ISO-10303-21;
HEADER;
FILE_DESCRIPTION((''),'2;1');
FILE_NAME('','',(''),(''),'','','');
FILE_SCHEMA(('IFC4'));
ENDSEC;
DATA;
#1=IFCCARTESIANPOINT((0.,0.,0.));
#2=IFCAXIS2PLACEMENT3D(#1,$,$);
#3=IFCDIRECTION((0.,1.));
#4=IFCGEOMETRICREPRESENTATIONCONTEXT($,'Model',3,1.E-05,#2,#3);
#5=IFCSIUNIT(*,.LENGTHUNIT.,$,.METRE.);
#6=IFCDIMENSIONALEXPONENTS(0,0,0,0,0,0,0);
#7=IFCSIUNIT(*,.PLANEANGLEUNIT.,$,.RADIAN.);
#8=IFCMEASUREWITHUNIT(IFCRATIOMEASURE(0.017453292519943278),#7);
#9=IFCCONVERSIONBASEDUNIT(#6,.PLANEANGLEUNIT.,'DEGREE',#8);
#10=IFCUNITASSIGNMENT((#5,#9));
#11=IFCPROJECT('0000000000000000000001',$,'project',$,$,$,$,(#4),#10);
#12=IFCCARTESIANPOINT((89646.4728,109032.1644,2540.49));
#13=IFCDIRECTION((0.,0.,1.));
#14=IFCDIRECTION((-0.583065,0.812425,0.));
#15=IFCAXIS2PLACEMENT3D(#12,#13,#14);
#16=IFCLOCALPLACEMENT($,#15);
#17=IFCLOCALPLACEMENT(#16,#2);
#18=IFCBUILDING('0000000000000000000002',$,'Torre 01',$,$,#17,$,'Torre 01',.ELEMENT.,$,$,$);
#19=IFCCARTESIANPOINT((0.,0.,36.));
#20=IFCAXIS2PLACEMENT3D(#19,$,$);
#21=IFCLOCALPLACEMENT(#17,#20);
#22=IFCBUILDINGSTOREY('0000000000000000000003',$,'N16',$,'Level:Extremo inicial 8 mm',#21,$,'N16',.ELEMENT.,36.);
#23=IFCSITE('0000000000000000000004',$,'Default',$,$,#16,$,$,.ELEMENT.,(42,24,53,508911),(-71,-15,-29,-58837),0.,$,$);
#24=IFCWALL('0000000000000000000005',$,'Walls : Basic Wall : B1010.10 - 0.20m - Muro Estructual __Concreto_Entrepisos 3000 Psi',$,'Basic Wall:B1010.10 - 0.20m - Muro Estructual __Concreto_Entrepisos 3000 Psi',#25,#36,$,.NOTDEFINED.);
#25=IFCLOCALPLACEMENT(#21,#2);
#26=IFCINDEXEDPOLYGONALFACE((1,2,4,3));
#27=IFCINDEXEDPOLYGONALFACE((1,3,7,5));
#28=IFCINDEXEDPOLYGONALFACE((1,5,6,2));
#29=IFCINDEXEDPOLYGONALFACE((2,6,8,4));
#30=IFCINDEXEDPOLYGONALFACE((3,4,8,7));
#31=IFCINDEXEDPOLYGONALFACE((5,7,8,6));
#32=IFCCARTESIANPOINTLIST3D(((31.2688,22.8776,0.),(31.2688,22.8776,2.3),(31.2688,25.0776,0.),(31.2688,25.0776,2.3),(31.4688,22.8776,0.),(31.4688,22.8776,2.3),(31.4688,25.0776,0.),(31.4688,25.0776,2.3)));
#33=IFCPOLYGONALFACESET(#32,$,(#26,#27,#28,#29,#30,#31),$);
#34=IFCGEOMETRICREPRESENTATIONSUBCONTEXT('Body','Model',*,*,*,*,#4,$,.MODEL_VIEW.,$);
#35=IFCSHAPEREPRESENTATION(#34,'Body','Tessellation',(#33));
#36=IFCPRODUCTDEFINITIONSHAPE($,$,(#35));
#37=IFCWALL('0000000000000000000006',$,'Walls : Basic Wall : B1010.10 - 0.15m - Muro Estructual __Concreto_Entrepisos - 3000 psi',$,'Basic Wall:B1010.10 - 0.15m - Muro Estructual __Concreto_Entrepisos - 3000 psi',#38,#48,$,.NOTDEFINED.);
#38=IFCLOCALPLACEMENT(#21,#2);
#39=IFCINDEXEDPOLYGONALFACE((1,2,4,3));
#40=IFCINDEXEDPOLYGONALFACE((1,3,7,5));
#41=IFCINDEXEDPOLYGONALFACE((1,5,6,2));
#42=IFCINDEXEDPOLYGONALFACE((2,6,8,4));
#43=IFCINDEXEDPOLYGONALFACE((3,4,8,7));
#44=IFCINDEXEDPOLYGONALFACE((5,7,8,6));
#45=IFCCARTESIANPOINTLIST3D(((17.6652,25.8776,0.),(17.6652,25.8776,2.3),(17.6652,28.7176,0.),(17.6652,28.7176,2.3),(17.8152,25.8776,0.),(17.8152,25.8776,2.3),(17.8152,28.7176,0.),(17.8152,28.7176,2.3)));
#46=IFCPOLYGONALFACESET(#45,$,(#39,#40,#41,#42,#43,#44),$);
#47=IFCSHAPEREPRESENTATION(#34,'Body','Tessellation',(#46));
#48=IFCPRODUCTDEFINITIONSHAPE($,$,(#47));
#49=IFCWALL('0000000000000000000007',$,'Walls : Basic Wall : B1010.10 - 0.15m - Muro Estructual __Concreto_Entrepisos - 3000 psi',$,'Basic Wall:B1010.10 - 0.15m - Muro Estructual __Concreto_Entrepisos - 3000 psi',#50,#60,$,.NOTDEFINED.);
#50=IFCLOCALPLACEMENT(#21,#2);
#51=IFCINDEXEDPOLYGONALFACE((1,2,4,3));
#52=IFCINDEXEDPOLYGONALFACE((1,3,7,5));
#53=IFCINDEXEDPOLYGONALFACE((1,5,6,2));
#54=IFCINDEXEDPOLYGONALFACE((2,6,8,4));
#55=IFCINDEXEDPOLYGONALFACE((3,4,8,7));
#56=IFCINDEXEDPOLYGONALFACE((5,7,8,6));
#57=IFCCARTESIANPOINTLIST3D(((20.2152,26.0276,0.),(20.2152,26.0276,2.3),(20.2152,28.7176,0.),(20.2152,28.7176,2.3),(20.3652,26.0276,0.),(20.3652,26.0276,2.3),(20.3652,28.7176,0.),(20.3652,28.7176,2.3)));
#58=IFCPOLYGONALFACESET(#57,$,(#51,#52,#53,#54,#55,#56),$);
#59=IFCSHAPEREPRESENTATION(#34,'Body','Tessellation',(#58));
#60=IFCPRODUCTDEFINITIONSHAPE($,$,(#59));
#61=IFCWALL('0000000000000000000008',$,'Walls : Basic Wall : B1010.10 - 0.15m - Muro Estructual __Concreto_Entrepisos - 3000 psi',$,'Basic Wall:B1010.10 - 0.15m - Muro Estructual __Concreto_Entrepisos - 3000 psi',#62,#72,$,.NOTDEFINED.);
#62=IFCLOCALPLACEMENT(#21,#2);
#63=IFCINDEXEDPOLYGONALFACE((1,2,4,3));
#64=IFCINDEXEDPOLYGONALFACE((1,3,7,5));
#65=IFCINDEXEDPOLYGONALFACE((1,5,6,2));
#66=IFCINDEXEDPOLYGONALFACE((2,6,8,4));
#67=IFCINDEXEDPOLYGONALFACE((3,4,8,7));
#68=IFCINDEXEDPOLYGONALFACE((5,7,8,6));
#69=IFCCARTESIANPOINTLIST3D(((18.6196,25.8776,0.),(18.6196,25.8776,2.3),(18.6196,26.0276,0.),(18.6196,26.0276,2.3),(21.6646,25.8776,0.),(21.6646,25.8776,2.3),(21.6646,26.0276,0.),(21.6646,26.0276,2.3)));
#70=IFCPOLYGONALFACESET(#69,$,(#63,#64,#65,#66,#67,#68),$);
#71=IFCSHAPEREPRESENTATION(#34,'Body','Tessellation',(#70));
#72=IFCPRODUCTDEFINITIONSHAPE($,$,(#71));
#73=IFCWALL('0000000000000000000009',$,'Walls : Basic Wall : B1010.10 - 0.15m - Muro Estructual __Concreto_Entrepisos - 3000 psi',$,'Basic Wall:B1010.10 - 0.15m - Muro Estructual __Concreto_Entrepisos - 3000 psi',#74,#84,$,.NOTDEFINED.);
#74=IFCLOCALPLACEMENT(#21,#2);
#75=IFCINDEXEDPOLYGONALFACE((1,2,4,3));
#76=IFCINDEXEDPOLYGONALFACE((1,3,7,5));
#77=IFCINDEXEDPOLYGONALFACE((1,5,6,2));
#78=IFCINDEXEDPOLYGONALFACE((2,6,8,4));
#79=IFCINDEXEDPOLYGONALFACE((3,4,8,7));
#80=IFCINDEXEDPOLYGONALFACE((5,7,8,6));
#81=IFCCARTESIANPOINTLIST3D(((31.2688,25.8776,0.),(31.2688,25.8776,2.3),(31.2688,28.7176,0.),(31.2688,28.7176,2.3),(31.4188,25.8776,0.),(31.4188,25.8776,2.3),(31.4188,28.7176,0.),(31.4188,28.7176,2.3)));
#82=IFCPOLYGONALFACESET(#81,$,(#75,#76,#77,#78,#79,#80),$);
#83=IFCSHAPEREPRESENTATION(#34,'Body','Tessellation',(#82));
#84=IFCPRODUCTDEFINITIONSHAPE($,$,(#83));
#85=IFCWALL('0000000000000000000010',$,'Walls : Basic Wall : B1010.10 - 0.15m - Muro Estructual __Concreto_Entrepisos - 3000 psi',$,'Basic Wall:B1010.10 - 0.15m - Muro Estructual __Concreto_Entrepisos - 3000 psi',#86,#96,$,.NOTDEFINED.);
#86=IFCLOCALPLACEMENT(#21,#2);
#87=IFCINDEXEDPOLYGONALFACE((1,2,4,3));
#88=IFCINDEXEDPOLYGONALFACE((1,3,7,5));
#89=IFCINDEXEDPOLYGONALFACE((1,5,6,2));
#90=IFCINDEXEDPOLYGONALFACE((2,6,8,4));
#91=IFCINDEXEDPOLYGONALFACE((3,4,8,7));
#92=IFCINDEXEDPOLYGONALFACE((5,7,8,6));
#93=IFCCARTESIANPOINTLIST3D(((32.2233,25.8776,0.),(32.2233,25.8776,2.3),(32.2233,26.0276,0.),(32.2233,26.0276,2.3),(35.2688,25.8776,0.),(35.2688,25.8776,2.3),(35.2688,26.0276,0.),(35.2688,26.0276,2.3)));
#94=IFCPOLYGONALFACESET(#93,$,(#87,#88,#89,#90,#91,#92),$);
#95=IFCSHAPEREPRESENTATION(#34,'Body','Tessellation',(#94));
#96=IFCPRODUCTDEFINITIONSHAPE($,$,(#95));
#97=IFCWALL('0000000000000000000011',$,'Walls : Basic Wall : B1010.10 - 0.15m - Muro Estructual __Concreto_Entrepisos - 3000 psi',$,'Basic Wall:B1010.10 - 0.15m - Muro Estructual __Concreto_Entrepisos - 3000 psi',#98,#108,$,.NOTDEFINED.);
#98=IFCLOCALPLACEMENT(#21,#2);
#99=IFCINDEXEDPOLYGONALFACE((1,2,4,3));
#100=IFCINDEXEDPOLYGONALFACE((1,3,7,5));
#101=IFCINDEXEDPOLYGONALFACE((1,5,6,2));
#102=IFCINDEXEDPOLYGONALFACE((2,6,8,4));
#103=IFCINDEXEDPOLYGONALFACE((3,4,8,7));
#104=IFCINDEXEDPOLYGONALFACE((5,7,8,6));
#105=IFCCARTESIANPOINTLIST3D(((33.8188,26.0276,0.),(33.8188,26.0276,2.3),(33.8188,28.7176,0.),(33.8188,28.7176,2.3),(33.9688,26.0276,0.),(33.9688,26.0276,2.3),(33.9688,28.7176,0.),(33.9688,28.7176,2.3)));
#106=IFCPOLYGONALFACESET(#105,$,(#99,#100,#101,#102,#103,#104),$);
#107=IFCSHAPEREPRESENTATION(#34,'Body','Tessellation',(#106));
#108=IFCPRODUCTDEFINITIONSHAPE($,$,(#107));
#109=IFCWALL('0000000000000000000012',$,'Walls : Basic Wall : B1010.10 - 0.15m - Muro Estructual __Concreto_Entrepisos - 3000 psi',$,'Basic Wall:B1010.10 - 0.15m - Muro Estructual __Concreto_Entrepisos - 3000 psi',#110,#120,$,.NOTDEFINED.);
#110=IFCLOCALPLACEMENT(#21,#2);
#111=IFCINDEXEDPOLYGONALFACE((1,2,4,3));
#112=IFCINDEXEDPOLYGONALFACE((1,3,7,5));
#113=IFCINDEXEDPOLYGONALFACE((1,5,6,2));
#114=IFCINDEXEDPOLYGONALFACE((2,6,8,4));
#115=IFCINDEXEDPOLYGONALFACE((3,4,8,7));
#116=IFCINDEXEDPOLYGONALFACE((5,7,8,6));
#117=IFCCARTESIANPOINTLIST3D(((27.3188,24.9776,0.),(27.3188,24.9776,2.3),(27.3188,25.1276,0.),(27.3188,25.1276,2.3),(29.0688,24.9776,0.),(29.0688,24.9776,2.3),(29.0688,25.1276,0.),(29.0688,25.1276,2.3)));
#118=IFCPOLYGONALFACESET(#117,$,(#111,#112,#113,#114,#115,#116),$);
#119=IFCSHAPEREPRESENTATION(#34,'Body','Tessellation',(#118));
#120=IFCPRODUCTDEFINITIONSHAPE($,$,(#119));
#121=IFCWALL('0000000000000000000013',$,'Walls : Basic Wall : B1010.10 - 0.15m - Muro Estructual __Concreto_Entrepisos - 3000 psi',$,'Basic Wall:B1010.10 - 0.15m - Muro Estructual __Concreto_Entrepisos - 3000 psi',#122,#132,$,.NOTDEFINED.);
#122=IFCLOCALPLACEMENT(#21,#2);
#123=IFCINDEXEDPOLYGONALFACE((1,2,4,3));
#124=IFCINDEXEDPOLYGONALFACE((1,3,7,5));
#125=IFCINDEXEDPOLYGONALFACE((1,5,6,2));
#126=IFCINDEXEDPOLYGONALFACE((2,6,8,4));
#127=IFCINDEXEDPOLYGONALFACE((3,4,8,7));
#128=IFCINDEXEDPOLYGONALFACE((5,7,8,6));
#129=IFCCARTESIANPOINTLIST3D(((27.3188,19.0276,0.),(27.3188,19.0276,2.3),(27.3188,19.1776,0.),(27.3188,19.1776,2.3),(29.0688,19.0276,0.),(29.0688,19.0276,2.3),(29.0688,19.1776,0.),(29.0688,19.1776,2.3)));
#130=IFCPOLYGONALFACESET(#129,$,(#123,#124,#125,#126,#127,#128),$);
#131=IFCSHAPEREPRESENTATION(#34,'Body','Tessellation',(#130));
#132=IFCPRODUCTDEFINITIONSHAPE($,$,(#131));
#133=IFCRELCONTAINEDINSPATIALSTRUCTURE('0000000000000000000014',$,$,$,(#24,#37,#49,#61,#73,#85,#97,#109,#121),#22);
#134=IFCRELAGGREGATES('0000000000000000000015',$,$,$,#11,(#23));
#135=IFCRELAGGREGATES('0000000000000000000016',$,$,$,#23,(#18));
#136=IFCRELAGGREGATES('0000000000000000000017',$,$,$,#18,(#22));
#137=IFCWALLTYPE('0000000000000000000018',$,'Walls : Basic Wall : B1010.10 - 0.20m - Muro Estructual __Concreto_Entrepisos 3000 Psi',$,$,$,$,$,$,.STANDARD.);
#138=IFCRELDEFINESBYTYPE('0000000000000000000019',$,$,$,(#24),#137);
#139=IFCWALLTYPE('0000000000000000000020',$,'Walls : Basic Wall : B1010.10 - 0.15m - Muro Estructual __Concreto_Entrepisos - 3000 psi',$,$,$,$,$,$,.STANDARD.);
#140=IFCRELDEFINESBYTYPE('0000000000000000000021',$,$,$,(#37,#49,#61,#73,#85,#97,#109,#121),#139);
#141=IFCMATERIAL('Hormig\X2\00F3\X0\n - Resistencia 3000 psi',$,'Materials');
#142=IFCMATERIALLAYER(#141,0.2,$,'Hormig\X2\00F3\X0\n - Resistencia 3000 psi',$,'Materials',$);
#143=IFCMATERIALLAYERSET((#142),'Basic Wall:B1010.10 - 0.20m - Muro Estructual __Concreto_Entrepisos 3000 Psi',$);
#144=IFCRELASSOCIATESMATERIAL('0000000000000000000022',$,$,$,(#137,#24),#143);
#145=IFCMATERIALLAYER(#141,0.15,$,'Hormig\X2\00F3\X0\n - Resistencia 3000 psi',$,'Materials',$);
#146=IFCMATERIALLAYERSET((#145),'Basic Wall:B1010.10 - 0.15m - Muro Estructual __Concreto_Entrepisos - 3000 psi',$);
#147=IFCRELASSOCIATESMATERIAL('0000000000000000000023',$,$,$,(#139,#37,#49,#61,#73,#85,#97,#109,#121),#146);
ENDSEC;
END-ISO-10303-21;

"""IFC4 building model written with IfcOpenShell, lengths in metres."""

from ifc_helpers import new_model, entity, si_unit, converted_unit, direction, frame, frame_2d, origin, place, context, subcontext, project, spatial, rectangle, extrude, material, layer, layer_set, layer_usage, type_object, element, save


model = new_model("IFC4")

# Units and contexts
model_context = context("Model", 3, precision=1e-05, world=origin(), true_north=direction((0.0, 1.0)))
body_context = subcontext(model_context, "Body", "Model", "MODEL_VIEW")
ifc_project = project(units=[si_unit("LENGTHUNIT", "METRE"), converted_unit("PLANEANGLEUNIT", "DEGREE", entity("IfcRatioMeasure", 0.017453292519943278), si_unit("PLANEANGLEUNIT", "RADIAN"), dimensions=[0, 0, 0, 0, 0, 0, 0])], contexts=[model_context])

# Site, building, storey
site_placement = place(None, frame((89646.4728, 109032.1644, 2540.49), z_axis=(0.0, 0.0, 1.0), x_axis=(-0.583065, 0.812425, 0.0)))
site = spatial("IfcSite", under=ifc_project, at=site_placement, Name="Default", CompositionType="ELEMENT", RefLatitude=(42, 24, 53, 508911), RefLongitude=(-71, -15, -29, -58837), RefElevation=0.0)
building_placement = place(site_placement, origin())
building = spatial("IfcBuilding", under=site, at=building_placement, Name="Torre 01", LongName="Torre 01", CompositionType="ELEMENT")
storey_placement = place(building_placement, frame((0.0, 0.0, 36.0)))
storey = spatial("IfcBuildingStorey", under=building, at=storey_placement, Name="N16", ObjectType="Level:Extremo inicial 8 mm", LongName="N16", CompositionType="ELEMENT", Elevation=36.0)

# Walls
ifc_material = material(Name="Hormigón - Resistencia 3000 psi", Category="Materials")
ifc_layer_1 = layer(ifc_material, 0.2, Name="Hormigón - Resistencia 3000 psi", Category="Materials")
ifc_layer_set_1 = layer_set([ifc_layer_1], Name="Basic Wall:B1010.10 - 0.20m - Muro Estructual __Concreto_Entrepisos 3000 Psi")
wall_type_1 = type_object("IfcWallType", Name="Walls : Basic Wall : B1010.10 - 0.20m - Muro Estructual __Concreto_Entrepisos 3000 Psi", PredefinedType="STANDARD", material=ifc_layer_set_1)
ifc_layer_usage_1 = layer_usage(ifc_layer_set_1, "AXIS2", "POSITIVE", -0.1)
wall_1_placement = place(storey_placement, frame((31.3688, 22.8776, 0.0), z_axis=(0.0, 0.0, 1.0), x_axis=(0.0, 1.0, 0.0)))
element("IfcWall", 1, at=wall_1_placement, inside=storey, type_object=wall_type_1, material=ifc_layer_usage_1, Name="Walls : Basic Wall : B1010.10 - 0.20m - Muro Estructual __Concreto_Entrepisos 3000 Psi", ObjectType="Basic Wall:B1010.10 - 0.20m - Muro Estructual __Concreto_Entrepisos 3000 Psi", PredefinedType="NOTDEFINED", context=body_context, shape_type="SweptSolid", body=[
    extrude(rectangle(XDim=2.2, YDim=0.2, at=frame_2d((1.1, 0.0), x_axis=(-1.0, 0.0))), origin(), (0.0, 0.0, 1.0), 2.3),
])
ifc_layer_2 = layer(ifc_material, 0.15, Name="Hormigón - Resistencia 3000 psi", Category="Materials")
ifc_layer_set_2 = layer_set([ifc_layer_2], Name="Basic Wall:B1010.10 - 0.15m - Muro Estructual __Concreto_Entrepisos - 3000 psi")
ifc_layer_usage_2 = layer_usage(ifc_layer_set_2, "AXIS2", "POSITIVE", -0.075)
wall_type_2 = type_object("IfcWallType", Name="Walls : Basic Wall : B1010.10 - 0.15m - Muro Estructual __Concreto_Entrepisos - 3000 psi", PredefinedType="STANDARD", material=ifc_layer_set_2)
wall_2_placement = place(storey_placement, frame((17.7402, 25.8776, 0.0), z_axis=(0.0, 0.0, 1.0), x_axis=(0.0, 1.0, 0.0)))
element("IfcWall", 2, at=wall_2_placement, inside=storey, type_object=wall_type_2, material=ifc_layer_usage_2, Name="Walls : Basic Wall : B1010.10 - 0.15m - Muro Estructual __Concreto_Entrepisos - 3000 psi", ObjectType="Basic Wall:B1010.10 - 0.15m - Muro Estructual __Concreto_Entrepisos - 3000 psi", PredefinedType="NOTDEFINED", context=body_context, shape_type="SweptSolid", body=[
    extrude(rectangle(XDim=2.84, YDim=0.15, at=frame_2d((1.42, 0.0), x_axis=(-1.0, 0.0))), origin(), (0.0, 0.0, 1.0), 2.3),
])
ifc_layer_usage_3 = layer_usage(ifc_layer_set_2, "AXIS2", "POSITIVE", -0.075)
wall_3_placement = place(storey_placement, frame((20.2902, 28.7176, 0.0), z_axis=(0.0, 0.0, 1.0), x_axis=(0.0, -1.0, 0.0)))
element("IfcWall", 3, at=wall_3_placement, inside=storey, type_object=wall_type_2, material=ifc_layer_usage_3, Name="Walls : Basic Wall : B1010.10 - 0.15m - Muro Estructual __Concreto_Entrepisos - 3000 psi", ObjectType="Basic Wall:B1010.10 - 0.15m - Muro Estructual __Concreto_Entrepisos - 3000 psi", PredefinedType="NOTDEFINED", context=body_context, shape_type="SweptSolid", body=[
    extrude(rectangle(XDim=2.69, YDim=0.15, at=frame_2d((1.345, 0.0), x_axis=(-1.0, 0.0))), origin(), (0.0, 0.0, 1.0), 2.3),
])
ifc_layer_usage_4 = layer_usage(ifc_layer_set_2, "AXIS2", "POSITIVE", -0.075)
wall_4_placement = place(storey_placement, frame((18.6196, 25.9526, 0.0)))
element("IfcWall", 4, at=wall_4_placement, inside=storey, type_object=wall_type_2, material=ifc_layer_usage_4, Name="Walls : Basic Wall : B1010.10 - 0.15m - Muro Estructual __Concreto_Entrepisos - 3000 psi", ObjectType="Basic Wall:B1010.10 - 0.15m - Muro Estructual __Concreto_Entrepisos - 3000 psi", PredefinedType="NOTDEFINED", context=body_context, shape_type="SweptSolid", body=[
    extrude(rectangle(XDim=3.045, YDim=0.15, at=frame_2d((1.5225, 0.0), x_axis=(-1.0, 0.0))), origin(), (0.0, 0.0, 1.0), 2.3),
])
ifc_layer_usage_5 = layer_usage(ifc_layer_set_2, "AXIS2", "POSITIVE", -0.075)
wall_5_placement = place(storey_placement, frame((31.3438, 28.7176, 0.0), z_axis=(0.0, 0.0, 1.0), x_axis=(0.0, -1.0, 0.0)))
element("IfcWall", 5, at=wall_5_placement, inside=storey, type_object=wall_type_2, material=ifc_layer_usage_5, Name="Walls : Basic Wall : B1010.10 - 0.15m - Muro Estructual __Concreto_Entrepisos - 3000 psi", ObjectType="Basic Wall:B1010.10 - 0.15m - Muro Estructual __Concreto_Entrepisos - 3000 psi", PredefinedType="NOTDEFINED", context=body_context, shape_type="SweptSolid", body=[
    extrude(rectangle(XDim=2.84, YDim=0.15, at=frame_2d((1.42, 0.0), x_axis=(-1.0, 0.0))), origin(), (0.0, 0.0, 1.0), 2.3),
])
ifc_layer_usage_6 = layer_usage(ifc_layer_set_2, "AXIS2", "POSITIVE", -0.075)
wall_6_placement = place(storey_placement, frame((32.2233, 25.9526, 0.0)))
element("IfcWall", 6, at=wall_6_placement, inside=storey, type_object=wall_type_2, material=ifc_layer_usage_6, Name="Walls : Basic Wall : B1010.10 - 0.15m - Muro Estructual __Concreto_Entrepisos - 3000 psi", ObjectType="Basic Wall:B1010.10 - 0.15m - Muro Estructual __Concreto_Entrepisos - 3000 psi", PredefinedType="NOTDEFINED", context=body_context, shape_type="SweptSolid", body=[
    extrude(rectangle(XDim=3.0455, YDim=0.15, at=frame_2d((1.5228, 0.0), x_axis=(-1.0, 0.0))), origin(), (0.0, 0.0, 1.0), 2.3),
])
ifc_layer_usage_7 = layer_usage(ifc_layer_set_2, "AXIS2", "POSITIVE", -0.075)
wall_7_placement = place(storey_placement, frame((33.8938, 26.0276, 0.0), z_axis=(0.0, 0.0, 1.0), x_axis=(0.0, 1.0, 0.0)))
element("IfcWall", 7, at=wall_7_placement, inside=storey, type_object=wall_type_2, material=ifc_layer_usage_7, Name="Walls : Basic Wall : B1010.10 - 0.15m - Muro Estructual __Concreto_Entrepisos - 3000 psi", ObjectType="Basic Wall:B1010.10 - 0.15m - Muro Estructual __Concreto_Entrepisos - 3000 psi", PredefinedType="NOTDEFINED", context=body_context, shape_type="SweptSolid", body=[
    extrude(rectangle(XDim=2.69, YDim=0.15, at=frame_2d((1.345, 0.0), x_axis=(-1.0, 0.0))), origin(), (0.0, 0.0, 1.0), 2.3),
])
ifc_layer_usage_8 = layer_usage(ifc_layer_set_2, "AXIS2", "NEGATIVE", 0.075)
wall_8_placement = place(storey_placement, frame((29.0688, 25.0526, 0.0), z_axis=(0.0, 0.0, 1.0), x_axis=(-1.0, 0.0, 0.0)))
element("IfcWall", 8, at=wall_8_placement, inside=storey, type_object=wall_type_2, material=ifc_layer_usage_8, Name="Walls : Basic Wall : B1010.10 - 0.15m - Muro Estructual __Concreto_Entrepisos - 3000 psi", ObjectType="Basic Wall:B1010.10 - 0.15m - Muro Estructual __Concreto_Entrepisos - 3000 psi", PredefinedType="NOTDEFINED", context=body_context, shape_type="SweptSolid", body=[
    extrude(rectangle(XDim=1.75, YDim=0.15, at=frame_2d((0.875, 0.0), x_axis=(-1.0, 0.0))), origin(), (0.0, 0.0, 1.0), 2.3),
])
ifc_layer_usage_9 = layer_usage(ifc_layer_set_2, "AXIS2", "POSITIVE", -0.075)
wall_9_placement = place(storey_placement, frame((29.0688, 19.1026, 0.0), z_axis=(0.0, 0.0, 1.0), x_axis=(-1.0, 0.0, 0.0)))
element("IfcWall", 9, at=wall_9_placement, inside=storey, type_object=wall_type_2, material=ifc_layer_usage_9, Name="Walls : Basic Wall : B1010.10 - 0.15m - Muro Estructual __Concreto_Entrepisos - 3000 psi", ObjectType="Basic Wall:B1010.10 - 0.15m - Muro Estructual __Concreto_Entrepisos - 3000 psi", PredefinedType="NOTDEFINED", context=body_context, shape_type="SweptSolid", body=[
    extrude(rectangle(XDim=1.75, YDim=0.15, at=frame_2d((0.875, 0.0), x_axis=(-1.0, 0.0))), origin(), (0.0, 0.0, 1.0), 2.3),
])

save(model, "model.ifc")
